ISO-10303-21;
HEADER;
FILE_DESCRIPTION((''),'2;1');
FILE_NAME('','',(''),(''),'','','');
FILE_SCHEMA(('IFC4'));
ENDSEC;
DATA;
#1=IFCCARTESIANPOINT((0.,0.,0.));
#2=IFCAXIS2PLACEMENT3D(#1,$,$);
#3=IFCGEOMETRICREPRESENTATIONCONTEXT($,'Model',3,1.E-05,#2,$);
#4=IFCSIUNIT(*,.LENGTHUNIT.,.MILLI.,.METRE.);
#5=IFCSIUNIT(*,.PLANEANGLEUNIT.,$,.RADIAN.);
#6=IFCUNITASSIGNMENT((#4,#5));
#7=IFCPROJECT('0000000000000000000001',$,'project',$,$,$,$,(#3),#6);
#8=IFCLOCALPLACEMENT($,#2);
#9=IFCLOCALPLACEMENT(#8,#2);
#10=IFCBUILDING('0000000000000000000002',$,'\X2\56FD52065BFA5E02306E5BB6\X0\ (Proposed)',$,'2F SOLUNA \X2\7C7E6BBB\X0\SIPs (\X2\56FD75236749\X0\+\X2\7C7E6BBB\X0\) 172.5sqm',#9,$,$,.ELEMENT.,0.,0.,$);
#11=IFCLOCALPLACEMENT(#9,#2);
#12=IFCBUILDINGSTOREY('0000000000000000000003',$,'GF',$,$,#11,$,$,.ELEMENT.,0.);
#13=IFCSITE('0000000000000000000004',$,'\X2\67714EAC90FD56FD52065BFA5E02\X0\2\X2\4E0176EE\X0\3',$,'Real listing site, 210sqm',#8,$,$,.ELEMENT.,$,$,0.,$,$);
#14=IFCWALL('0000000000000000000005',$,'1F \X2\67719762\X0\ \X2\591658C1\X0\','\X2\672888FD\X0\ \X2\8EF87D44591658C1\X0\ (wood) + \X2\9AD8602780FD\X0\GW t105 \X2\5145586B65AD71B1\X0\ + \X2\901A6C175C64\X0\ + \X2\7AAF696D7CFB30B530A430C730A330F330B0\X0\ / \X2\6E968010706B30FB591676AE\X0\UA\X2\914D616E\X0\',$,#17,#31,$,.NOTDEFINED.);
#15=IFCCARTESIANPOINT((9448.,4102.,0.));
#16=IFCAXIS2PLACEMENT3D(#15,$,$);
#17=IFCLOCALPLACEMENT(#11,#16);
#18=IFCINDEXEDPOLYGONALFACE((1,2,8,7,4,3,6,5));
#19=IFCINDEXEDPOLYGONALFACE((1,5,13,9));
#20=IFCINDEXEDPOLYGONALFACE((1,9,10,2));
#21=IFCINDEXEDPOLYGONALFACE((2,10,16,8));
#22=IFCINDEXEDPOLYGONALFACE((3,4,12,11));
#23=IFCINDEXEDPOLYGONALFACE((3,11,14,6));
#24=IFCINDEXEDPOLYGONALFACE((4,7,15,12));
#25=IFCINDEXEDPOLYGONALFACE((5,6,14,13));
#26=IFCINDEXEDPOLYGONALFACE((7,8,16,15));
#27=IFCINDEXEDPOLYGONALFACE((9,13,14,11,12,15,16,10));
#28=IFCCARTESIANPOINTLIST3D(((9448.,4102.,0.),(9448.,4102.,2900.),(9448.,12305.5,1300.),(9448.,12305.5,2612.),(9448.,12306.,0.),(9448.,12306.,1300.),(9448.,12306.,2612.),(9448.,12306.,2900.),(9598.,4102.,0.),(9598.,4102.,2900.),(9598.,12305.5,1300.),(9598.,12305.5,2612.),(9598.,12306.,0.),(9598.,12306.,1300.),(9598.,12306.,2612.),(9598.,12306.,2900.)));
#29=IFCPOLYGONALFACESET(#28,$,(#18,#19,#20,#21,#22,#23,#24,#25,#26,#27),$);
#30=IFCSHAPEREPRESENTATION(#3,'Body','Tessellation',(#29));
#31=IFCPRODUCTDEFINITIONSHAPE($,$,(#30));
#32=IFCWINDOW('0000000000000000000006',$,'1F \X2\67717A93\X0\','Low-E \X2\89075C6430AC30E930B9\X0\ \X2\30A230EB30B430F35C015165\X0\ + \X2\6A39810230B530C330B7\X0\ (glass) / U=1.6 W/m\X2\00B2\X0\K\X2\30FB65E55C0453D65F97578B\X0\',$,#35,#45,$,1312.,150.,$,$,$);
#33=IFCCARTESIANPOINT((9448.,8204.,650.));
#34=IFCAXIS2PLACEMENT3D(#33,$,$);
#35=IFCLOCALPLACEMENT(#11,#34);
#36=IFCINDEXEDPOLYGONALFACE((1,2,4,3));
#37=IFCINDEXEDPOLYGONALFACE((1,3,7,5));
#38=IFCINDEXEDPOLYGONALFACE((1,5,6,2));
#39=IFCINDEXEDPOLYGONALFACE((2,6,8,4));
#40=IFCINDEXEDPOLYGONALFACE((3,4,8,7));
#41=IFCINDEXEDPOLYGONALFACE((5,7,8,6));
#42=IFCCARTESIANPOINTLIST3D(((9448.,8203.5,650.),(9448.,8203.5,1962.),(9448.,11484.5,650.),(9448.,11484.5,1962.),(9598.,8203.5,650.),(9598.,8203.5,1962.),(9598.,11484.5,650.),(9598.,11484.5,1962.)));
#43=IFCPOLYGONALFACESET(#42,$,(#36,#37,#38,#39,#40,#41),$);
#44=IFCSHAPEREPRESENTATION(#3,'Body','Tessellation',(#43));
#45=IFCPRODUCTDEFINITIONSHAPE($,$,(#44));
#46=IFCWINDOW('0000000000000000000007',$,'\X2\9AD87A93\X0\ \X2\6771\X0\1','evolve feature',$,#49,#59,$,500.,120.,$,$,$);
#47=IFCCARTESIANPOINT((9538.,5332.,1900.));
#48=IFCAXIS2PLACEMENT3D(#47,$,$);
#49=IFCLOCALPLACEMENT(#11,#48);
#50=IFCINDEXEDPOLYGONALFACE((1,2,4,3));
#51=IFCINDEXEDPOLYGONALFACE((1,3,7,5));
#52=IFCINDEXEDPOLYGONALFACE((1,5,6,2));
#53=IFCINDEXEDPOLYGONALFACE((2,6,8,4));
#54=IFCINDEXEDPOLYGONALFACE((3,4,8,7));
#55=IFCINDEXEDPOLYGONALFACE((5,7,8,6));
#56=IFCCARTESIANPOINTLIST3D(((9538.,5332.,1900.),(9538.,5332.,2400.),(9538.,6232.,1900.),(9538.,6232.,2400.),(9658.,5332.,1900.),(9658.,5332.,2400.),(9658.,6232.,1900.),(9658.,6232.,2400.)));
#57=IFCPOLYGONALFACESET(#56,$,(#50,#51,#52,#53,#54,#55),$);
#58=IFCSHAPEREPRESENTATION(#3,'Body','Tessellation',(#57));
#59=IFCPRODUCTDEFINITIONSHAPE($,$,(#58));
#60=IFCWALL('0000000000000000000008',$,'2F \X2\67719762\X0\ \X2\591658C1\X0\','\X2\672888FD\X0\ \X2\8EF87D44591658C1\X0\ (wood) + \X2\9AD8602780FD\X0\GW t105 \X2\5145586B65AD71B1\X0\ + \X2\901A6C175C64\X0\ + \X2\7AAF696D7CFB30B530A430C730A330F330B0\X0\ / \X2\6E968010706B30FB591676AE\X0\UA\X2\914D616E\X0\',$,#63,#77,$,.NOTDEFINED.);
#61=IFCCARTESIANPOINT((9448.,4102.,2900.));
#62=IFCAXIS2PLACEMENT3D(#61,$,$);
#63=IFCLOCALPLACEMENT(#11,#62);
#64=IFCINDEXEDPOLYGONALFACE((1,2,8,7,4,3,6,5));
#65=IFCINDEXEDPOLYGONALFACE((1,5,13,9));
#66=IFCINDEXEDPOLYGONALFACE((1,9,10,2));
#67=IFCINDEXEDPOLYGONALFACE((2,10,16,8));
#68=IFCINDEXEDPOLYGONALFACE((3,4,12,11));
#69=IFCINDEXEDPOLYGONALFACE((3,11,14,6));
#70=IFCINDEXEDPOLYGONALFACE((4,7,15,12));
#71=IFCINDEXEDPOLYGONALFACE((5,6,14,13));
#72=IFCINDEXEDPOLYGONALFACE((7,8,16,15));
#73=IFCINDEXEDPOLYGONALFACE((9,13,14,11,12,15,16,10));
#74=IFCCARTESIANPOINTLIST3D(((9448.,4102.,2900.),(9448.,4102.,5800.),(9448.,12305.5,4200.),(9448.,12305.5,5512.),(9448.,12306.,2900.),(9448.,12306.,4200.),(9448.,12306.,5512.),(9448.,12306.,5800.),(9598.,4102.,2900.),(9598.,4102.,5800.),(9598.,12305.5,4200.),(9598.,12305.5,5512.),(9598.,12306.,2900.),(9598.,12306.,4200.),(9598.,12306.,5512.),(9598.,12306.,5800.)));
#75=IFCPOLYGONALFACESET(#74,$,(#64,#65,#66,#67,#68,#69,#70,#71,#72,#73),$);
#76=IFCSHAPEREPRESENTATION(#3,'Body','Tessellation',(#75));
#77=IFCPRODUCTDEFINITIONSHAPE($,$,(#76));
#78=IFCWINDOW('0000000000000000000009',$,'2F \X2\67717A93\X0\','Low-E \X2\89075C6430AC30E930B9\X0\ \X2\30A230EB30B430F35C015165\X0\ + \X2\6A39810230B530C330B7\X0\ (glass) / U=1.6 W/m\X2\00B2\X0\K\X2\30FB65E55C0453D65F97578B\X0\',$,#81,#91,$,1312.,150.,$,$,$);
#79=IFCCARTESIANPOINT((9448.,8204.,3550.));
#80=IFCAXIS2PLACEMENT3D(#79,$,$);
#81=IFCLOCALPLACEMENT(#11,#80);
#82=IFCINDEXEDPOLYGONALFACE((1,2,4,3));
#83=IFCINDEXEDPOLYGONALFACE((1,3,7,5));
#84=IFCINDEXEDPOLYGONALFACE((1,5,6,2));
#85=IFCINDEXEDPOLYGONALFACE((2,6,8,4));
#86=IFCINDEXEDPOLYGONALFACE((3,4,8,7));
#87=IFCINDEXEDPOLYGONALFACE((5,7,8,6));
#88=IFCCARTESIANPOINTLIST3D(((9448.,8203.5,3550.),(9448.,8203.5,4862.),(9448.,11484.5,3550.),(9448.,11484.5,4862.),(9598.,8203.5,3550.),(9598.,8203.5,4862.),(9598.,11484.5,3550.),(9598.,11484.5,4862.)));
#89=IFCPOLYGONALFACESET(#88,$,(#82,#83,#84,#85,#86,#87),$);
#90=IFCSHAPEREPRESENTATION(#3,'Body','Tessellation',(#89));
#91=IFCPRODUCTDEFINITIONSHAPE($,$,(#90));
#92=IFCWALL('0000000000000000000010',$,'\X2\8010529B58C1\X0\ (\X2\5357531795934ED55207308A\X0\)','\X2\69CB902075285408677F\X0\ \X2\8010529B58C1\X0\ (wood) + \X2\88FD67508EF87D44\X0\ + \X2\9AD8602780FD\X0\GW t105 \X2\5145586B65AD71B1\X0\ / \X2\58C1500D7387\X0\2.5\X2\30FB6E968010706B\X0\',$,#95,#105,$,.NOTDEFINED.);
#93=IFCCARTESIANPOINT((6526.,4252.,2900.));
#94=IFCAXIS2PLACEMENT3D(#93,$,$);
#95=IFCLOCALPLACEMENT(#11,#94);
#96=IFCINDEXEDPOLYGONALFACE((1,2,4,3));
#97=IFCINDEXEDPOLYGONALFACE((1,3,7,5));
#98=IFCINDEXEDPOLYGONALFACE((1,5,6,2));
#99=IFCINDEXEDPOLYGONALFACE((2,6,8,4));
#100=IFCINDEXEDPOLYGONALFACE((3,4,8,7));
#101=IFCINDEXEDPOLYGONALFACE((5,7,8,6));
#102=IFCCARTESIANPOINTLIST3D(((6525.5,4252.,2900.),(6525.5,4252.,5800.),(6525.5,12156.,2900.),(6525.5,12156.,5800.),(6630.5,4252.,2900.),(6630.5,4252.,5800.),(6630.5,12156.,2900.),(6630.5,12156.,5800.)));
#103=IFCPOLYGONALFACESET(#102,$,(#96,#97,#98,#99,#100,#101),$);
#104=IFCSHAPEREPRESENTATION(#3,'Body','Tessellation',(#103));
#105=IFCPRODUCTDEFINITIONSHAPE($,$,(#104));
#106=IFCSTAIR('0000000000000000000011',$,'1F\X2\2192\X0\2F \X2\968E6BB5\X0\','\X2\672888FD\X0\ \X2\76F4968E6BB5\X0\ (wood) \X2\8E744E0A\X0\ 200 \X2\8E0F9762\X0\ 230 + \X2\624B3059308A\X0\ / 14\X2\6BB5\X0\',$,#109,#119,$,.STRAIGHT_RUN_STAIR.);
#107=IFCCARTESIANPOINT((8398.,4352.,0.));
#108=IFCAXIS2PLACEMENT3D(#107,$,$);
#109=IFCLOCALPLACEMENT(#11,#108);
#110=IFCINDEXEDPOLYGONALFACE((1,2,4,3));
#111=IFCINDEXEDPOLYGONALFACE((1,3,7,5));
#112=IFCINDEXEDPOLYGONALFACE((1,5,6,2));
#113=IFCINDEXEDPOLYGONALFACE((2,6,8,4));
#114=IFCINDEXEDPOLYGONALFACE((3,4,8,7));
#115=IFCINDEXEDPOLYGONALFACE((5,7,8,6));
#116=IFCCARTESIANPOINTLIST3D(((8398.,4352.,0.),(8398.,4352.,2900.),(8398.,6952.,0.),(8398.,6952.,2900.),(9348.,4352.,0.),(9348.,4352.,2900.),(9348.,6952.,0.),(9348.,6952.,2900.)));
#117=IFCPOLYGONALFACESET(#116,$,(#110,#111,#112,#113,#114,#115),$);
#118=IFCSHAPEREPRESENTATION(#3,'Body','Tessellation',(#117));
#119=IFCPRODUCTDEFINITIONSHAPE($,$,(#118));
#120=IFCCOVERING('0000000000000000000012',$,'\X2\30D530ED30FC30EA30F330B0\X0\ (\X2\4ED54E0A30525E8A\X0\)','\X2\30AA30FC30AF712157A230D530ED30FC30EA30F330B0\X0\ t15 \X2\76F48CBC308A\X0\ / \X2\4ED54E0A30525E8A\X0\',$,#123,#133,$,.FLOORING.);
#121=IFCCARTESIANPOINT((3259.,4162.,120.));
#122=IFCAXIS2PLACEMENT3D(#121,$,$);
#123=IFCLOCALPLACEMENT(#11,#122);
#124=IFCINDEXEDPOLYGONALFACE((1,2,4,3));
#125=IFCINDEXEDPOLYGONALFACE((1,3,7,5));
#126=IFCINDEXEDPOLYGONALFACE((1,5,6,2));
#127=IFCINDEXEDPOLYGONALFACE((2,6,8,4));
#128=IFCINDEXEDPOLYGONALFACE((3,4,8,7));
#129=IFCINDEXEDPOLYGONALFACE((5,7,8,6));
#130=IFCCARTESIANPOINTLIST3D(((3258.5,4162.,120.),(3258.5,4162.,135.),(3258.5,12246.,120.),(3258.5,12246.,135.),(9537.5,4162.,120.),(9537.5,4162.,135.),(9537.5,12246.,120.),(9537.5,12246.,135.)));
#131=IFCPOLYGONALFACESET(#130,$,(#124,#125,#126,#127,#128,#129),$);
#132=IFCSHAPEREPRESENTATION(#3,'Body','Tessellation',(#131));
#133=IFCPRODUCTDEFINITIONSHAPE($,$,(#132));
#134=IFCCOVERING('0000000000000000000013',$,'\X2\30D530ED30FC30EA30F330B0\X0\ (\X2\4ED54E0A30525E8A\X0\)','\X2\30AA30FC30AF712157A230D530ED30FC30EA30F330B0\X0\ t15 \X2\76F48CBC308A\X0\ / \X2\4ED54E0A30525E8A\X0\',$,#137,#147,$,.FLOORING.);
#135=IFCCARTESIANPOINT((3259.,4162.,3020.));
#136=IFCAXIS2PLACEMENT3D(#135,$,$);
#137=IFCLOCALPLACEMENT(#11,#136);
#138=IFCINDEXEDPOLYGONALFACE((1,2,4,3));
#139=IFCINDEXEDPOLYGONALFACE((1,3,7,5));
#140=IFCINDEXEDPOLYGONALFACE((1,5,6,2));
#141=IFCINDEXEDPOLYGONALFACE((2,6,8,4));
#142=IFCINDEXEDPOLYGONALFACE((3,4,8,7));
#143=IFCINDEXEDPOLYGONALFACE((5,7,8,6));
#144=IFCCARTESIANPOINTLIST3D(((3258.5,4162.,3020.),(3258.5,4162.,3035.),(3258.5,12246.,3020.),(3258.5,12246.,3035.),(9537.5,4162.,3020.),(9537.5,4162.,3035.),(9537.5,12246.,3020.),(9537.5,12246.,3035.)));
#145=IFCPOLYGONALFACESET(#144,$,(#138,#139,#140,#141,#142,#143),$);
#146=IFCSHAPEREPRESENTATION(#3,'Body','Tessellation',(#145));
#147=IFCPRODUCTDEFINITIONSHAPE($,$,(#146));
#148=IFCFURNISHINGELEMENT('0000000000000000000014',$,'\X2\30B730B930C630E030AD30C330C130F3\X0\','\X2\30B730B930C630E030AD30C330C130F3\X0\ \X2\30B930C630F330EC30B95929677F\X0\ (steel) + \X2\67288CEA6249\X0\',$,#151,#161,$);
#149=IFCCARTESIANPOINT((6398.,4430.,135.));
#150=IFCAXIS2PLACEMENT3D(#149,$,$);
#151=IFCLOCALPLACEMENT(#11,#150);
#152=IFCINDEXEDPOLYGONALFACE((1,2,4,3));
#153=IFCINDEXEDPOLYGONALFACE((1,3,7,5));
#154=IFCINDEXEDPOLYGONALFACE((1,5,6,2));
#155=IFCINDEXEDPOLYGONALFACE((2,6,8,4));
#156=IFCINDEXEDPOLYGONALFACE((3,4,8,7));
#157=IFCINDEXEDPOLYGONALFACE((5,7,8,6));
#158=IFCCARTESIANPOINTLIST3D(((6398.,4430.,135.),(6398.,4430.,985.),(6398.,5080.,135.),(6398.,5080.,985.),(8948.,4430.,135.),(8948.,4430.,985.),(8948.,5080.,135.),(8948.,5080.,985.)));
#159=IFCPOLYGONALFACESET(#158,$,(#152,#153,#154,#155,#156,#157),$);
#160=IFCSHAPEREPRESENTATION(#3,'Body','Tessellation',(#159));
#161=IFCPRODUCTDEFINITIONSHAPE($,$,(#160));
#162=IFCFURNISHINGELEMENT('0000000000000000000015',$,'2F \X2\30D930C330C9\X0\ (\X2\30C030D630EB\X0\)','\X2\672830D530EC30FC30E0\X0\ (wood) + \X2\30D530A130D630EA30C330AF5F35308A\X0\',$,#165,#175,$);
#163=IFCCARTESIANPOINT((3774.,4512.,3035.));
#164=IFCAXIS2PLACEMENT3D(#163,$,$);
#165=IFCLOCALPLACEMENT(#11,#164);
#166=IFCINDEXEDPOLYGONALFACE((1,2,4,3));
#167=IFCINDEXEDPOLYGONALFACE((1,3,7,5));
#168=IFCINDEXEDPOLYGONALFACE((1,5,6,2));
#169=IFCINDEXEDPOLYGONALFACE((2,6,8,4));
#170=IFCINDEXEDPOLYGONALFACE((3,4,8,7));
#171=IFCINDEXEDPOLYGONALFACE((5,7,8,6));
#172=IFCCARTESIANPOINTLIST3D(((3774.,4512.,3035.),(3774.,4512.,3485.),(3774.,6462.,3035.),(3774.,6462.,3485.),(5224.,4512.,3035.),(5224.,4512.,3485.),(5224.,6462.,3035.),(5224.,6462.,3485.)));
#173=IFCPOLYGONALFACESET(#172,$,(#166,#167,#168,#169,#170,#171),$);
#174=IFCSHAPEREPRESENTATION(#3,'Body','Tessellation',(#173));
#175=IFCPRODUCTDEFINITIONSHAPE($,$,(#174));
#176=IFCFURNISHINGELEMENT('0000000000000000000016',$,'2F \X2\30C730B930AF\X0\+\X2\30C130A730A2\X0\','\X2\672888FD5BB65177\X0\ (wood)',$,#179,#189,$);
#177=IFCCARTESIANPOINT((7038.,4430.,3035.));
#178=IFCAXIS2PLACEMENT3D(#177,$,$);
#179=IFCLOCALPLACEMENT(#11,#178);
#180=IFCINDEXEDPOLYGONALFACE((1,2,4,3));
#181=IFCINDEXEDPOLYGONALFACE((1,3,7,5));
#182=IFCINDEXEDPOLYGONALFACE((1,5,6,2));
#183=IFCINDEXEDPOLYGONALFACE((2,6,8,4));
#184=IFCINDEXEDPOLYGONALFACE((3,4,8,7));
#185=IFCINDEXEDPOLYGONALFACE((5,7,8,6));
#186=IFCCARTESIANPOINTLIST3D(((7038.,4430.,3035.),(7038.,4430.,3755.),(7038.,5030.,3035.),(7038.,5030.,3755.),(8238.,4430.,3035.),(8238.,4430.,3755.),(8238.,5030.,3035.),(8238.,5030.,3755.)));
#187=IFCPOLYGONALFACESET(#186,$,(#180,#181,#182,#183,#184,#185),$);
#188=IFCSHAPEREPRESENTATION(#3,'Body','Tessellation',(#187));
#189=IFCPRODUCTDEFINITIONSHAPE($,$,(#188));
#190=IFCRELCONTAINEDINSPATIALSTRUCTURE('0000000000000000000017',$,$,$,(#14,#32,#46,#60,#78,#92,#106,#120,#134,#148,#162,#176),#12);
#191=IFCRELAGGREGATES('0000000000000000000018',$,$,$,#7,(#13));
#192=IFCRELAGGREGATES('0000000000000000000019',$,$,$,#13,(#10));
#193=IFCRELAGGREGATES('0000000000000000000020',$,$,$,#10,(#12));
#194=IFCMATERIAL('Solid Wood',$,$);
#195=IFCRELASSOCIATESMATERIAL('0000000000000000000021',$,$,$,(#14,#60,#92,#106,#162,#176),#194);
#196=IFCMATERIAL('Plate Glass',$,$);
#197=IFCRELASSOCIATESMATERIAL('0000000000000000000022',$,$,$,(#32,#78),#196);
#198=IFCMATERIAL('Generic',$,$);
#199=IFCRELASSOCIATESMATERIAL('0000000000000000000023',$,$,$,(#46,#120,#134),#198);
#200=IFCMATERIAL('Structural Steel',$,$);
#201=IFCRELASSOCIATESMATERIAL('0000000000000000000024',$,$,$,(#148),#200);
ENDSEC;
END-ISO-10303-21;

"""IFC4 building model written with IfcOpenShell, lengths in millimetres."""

from ifc_helpers import new_model, si_unit, frame, frame_2d, origin, place, context, project, spatial, rectangle, extrude, material, element, fill, save


model = new_model("IFC4")

# Units and contexts
model_context = context("Model", 3, precision=1e-05, world=origin())
ifc_project = project(units=[si_unit("LENGTHUNIT", "METRE", prefix="MILLI"), si_unit("PLANEANGLEUNIT", "RADIAN")], contexts=[model_context])

# Site, building, storey
site_placement = place(None, origin())
site = spatial("IfcSite", under=ifc_project, at=site_placement, Name="東京都国分寺市2丁目3", ObjectType="Real listing site, 210sqm", CompositionType="ELEMENT", RefElevation=0.0)
building_placement = place(site_placement, origin())
building = spatial("IfcBuilding", under=site, at=building_placement, Name="国分寺市の家 (Proposed)", ObjectType="2F SOLUNA 籾殻SIPs (国産杉+籾殻) 172.5sqm", CompositionType="ELEMENT", ElevationOfRefHeight=0.0, ElevationOfTerrain=0.0)
storey_placement = place(building_placement, origin())
storey = spatial("IfcBuildingStorey", under=building, at=storey_placement, Name="GF", CompositionType="ELEMENT", Elevation=0.0)

# Shared definitions
ifc_material_1 = material(Name="Solid Wood")

# Wall, openings, windows
wall_1_placement = place(storey_placement, frame((9448.0, 4102.0, 0.0)))
wall_1 = element("IfcWall", 1, at=wall_1_placement, inside=storey, material=ifc_material_1, Name="1F 東面 外壁", Description="木製 軸組外壁 (wood) + 高性能GW t105 充填断熱 + 通気層 + 窯業系サイディング / 準耐火・外皮UA配慮", PredefinedType="NOTDEFINED", context=model_context, shape_type="SweptSolid", body=[
    extrude(rectangle(XDim=150.0, YDim=8204.0, at=frame_2d((75.0, 4102.0))), frame((9448.0, 4102.0, 0.0)), (0.0, 0.0, 1.0), 2900.0),
])
opening_1_placement = place(storey_placement, frame((9448.0, 8204.0, 650.0)))
opening_1 = element("IfcOpeningElement", 2, at=opening_1_placement, cuts=wall_1, PredefinedType="NOTDEFINED", context=model_context, shape_type="SweptSolid", body=[
    extrude(rectangle(XDim=150.0, YDim=3281.0, at=frame_2d((75.0, 1640.0))), frame((9448.0, 8204.0, 650.0)), (0.0, 0.0, 1.0), 1312.0),
])
opening_2_placement = place(storey_placement, frame((9538.0, 5332.0, 1900.0)))
opening_2 = element("IfcOpeningElement", 3, at=opening_2_placement, cuts=wall_1, PredefinedType="NOTDEFINED", context=model_context, shape_type="SweptSolid", body=[
    extrude(rectangle(XDim=120.0, YDim=900.0, at=frame_2d((60.0, 450.0))), frame((9538.0, 5332.0, 1900.0)), (0.0, 0.0, 1.0), 500.0),
])
ifc_material_2 = material(Name="Plate Glass")
window_1_placement = place(storey_placement, frame((9448.0, 8204.0, 650.0)))
window_1 = element("IfcWindow", 4, at=window_1_placement, inside=storey, material=ifc_material_2, Name="1F 東窓", Description="Low-E 複層ガラス アルゴン封入 + 樹脂サッシ (glass) / U=1.6 W/m²K・日射取得型", OverallHeight=1312.0, OverallWidth=150.0, context=model_context, shape_type="SweptSolid", body=[
    extrude(rectangle(XDim=150.0, YDim=3281.0, at=frame_2d((75.0, 1640.0))), frame((9448.0, 8204.0, 650.0)), (0.0, 0.0, 1.0), 1312.0),
])
fill(opening_1, window_1)
ifc_material_3 = material(Name="Generic")
window_2_placement = place(storey_placement, frame((9538.0, 5332.0, 1900.0)))
window_2 = element("IfcWindow", 5, at=window_2_placement, inside=storey, material=ifc_material_3, Name="高窓 東1", Description="evolve feature", OverallHeight=500.0, OverallWidth=120.0, context=model_context, shape_type="SweptSolid", body=[
    extrude(rectangle(XDim=120.0, YDim=900.0, at=frame_2d((60.0, 450.0))), frame((9538.0, 5332.0, 1900.0)), (0.0, 0.0, 1.0), 500.0),
])
fill(opening_2, window_2)

# Wall, opening, window
wall_2_placement = place(storey_placement, frame((9448.0, 4102.0, 2900.0)))
wall_2 = element("IfcWall", 6, at=wall_2_placement, inside=storey, material=ifc_material_1, Name="2F 東面 外壁", Description="木製 軸組外壁 (wood) + 高性能GW t105 充填断熱 + 通気層 + 窯業系サイディング / 準耐火・外皮UA配慮", PredefinedType="NOTDEFINED", context=model_context, shape_type="SweptSolid", body=[
    extrude(rectangle(XDim=150.0, YDim=8204.0, at=frame_2d((75.0, 4102.0))), frame((9448.0, 4102.0, 2900.0)), (0.0, 0.0, 1.0), 2900.0),
])
opening_3_placement = place(storey_placement, frame((9448.0, 8204.0, 3550.0)))
opening_3 = element("IfcOpeningElement", 7, at=opening_3_placement, cuts=wall_2, PredefinedType="NOTDEFINED", context=model_context, shape_type="SweptSolid", body=[
    extrude(rectangle(XDim=150.0, YDim=3281.0, at=frame_2d((75.0, 1640.0))), frame((9448.0, 8204.0, 3550.0)), (0.0, 0.0, 1.0), 1312.0),
])
window_3_placement = place(storey_placement, frame((9448.0, 8204.0, 3550.0)))
window_3 = element("IfcWindow", 8, at=window_3_placement, inside=storey, material=ifc_material_2, Name="2F 東窓", Description="Low-E 複層ガラス アルゴン封入 + 樹脂サッシ (glass) / U=1.6 W/m²K・日射取得型", OverallHeight=1312.0, OverallWidth=150.0, context=model_context, shape_type="SweptSolid", body=[
    extrude(rectangle(XDim=150.0, YDim=3281.0, at=frame_2d((75.0, 1640.0))), frame((9448.0, 8204.0, 3550.0)), (0.0, 0.0, 1.0), 1312.0),
])
fill(opening_3, window_3)

# Wall
wall_3_placement = place(storey_placement, frame((6526.0, 4252.0, 2900.0)))
element("IfcWall", 9, at=wall_3_placement, inside=storey, material=ifc_material_1, Name="耐力壁 (南北間仕切り)", Description="構造用合板 耐力壁 (wood) + 製材軸組 + 高性能GW t105 充填断熱 / 壁倍率2.5・準耐火", PredefinedType="NOTDEFINED", context=model_context, shape_type="SweptSolid", body=[
    extrude(rectangle(XDim=105.0, YDim=7904.0, at=frame_2d((52.0, 3952.0))), frame((6526.0, 4252.0, 2900.0)), (0.0, 0.0, 1.0), 2900.0),
])

# Stair
stair_placement = place(storey_placement, frame((8398.0, 4352.0, 0.0)))
element("IfcStair", 10, at=stair_placement, inside=storey, material=ifc_material_1, Name="1F→2F 階段", Description="木製 直階段 (wood) 蹴上 200 踏面 230 + 手すり / 14段", PredefinedType="STRAIGHT_RUN_STAIR", context=model_context, shape_type="SweptSolid", body=[
    extrude(rectangle(XDim=950.0, YDim=2600.0, at=frame_2d((475.0, 1300.0))), frame((8398.0, 4352.0, 0.0)), (0.0, 0.0, 1.0), 2900.0),
])

# Coverings
covering_1_placement = place(storey_placement, frame((3259.0, 4162.0, 120.0)))
element("IfcCovering", 11, at=covering_1_placement, inside=storey, material=ifc_material_3, Name="フローリング (仕上げ床)", Description="オーク無垢フローリング t15 直貼り / 仕上げ床", PredefinedType="FLOORING", context=model_context, shape_type="SweptSolid", body=[
    extrude(rectangle(XDim=6279.0, YDim=8084.0, at=frame_2d((3139.0, 4042.0))), frame((3259.0, 4162.0, 120.0)), (0.0, 0.0, 1.0), 15.0),
])
covering_2_placement = place(storey_placement, frame((3259.0, 4162.0, 3020.0)))
element("IfcCovering", 12, at=covering_2_placement, inside=storey, material=ifc_material_3, Name="フローリング (仕上げ床)", Description="オーク無垢フローリング t15 直貼り / 仕上げ床", PredefinedType="FLOORING", context=model_context, shape_type="SweptSolid", body=[
    extrude(rectangle(XDim=6279.0, YDim=8084.0, at=frame_2d((3139.0, 4042.0))), frame((3259.0, 4162.0, 3020.0)), (0.0, 0.0, 1.0), 15.0),
])

# Furnishing elements
ifc_material_4 = material(Name="Structural Steel")
furnishing_1_placement = place(storey_placement, frame((6398.0, 4430.0, 135.0)))
element("IfcFurnishingElement", 13, at=furnishing_1_placement, inside=storey, material=ifc_material_4, Name="システムキッチン", Description="システムキッチン ステンレス天板 (steel) + 木質扉", context=model_context, shape_type="SweptSolid", body=[
    extrude(rectangle(XDim=2550.0, YDim=650.0, at=frame_2d((1275.0, 325.0))), frame((6398.0, 4430.0, 135.0)), (0.0, 0.0, 1.0), 850.0),
])
furnishing_2_placement = place(storey_placement, frame((3774.0, 4512.0, 3035.0)))
element("IfcFurnishingElement", 14, at=furnishing_2_placement, inside=storey, material=ifc_material_1, Name="2F ベッド (ダブル)", Description="木フレーム (wood) + ファブリック張り", context=model_context, shape_type="SweptSolid", body=[
    extrude(rectangle(XDim=1450.0, YDim=1950.0, at=frame_2d((725.0, 975.0))), frame((3774.0, 4512.0, 3035.0)), (0.0, 0.0, 1.0), 450.0),
])
furnishing_3_placement = place(storey_placement, frame((7038.0, 4430.0, 3035.0)))
element("IfcFurnishingElement", 15, at=furnishing_3_placement, inside=storey, material=ifc_material_1, Name="2F デスク+チェア", Description="木製家具 (wood)", context=model_context, shape_type="SweptSolid", body=[
    extrude(rectangle(XDim=1200.0, YDim=600.0, at=frame_2d((600.0, 300.0))), frame((7038.0, 4430.0, 3035.0)), (0.0, 0.0, 1.0), 720.0),
])

save(model, "model.ifc")
